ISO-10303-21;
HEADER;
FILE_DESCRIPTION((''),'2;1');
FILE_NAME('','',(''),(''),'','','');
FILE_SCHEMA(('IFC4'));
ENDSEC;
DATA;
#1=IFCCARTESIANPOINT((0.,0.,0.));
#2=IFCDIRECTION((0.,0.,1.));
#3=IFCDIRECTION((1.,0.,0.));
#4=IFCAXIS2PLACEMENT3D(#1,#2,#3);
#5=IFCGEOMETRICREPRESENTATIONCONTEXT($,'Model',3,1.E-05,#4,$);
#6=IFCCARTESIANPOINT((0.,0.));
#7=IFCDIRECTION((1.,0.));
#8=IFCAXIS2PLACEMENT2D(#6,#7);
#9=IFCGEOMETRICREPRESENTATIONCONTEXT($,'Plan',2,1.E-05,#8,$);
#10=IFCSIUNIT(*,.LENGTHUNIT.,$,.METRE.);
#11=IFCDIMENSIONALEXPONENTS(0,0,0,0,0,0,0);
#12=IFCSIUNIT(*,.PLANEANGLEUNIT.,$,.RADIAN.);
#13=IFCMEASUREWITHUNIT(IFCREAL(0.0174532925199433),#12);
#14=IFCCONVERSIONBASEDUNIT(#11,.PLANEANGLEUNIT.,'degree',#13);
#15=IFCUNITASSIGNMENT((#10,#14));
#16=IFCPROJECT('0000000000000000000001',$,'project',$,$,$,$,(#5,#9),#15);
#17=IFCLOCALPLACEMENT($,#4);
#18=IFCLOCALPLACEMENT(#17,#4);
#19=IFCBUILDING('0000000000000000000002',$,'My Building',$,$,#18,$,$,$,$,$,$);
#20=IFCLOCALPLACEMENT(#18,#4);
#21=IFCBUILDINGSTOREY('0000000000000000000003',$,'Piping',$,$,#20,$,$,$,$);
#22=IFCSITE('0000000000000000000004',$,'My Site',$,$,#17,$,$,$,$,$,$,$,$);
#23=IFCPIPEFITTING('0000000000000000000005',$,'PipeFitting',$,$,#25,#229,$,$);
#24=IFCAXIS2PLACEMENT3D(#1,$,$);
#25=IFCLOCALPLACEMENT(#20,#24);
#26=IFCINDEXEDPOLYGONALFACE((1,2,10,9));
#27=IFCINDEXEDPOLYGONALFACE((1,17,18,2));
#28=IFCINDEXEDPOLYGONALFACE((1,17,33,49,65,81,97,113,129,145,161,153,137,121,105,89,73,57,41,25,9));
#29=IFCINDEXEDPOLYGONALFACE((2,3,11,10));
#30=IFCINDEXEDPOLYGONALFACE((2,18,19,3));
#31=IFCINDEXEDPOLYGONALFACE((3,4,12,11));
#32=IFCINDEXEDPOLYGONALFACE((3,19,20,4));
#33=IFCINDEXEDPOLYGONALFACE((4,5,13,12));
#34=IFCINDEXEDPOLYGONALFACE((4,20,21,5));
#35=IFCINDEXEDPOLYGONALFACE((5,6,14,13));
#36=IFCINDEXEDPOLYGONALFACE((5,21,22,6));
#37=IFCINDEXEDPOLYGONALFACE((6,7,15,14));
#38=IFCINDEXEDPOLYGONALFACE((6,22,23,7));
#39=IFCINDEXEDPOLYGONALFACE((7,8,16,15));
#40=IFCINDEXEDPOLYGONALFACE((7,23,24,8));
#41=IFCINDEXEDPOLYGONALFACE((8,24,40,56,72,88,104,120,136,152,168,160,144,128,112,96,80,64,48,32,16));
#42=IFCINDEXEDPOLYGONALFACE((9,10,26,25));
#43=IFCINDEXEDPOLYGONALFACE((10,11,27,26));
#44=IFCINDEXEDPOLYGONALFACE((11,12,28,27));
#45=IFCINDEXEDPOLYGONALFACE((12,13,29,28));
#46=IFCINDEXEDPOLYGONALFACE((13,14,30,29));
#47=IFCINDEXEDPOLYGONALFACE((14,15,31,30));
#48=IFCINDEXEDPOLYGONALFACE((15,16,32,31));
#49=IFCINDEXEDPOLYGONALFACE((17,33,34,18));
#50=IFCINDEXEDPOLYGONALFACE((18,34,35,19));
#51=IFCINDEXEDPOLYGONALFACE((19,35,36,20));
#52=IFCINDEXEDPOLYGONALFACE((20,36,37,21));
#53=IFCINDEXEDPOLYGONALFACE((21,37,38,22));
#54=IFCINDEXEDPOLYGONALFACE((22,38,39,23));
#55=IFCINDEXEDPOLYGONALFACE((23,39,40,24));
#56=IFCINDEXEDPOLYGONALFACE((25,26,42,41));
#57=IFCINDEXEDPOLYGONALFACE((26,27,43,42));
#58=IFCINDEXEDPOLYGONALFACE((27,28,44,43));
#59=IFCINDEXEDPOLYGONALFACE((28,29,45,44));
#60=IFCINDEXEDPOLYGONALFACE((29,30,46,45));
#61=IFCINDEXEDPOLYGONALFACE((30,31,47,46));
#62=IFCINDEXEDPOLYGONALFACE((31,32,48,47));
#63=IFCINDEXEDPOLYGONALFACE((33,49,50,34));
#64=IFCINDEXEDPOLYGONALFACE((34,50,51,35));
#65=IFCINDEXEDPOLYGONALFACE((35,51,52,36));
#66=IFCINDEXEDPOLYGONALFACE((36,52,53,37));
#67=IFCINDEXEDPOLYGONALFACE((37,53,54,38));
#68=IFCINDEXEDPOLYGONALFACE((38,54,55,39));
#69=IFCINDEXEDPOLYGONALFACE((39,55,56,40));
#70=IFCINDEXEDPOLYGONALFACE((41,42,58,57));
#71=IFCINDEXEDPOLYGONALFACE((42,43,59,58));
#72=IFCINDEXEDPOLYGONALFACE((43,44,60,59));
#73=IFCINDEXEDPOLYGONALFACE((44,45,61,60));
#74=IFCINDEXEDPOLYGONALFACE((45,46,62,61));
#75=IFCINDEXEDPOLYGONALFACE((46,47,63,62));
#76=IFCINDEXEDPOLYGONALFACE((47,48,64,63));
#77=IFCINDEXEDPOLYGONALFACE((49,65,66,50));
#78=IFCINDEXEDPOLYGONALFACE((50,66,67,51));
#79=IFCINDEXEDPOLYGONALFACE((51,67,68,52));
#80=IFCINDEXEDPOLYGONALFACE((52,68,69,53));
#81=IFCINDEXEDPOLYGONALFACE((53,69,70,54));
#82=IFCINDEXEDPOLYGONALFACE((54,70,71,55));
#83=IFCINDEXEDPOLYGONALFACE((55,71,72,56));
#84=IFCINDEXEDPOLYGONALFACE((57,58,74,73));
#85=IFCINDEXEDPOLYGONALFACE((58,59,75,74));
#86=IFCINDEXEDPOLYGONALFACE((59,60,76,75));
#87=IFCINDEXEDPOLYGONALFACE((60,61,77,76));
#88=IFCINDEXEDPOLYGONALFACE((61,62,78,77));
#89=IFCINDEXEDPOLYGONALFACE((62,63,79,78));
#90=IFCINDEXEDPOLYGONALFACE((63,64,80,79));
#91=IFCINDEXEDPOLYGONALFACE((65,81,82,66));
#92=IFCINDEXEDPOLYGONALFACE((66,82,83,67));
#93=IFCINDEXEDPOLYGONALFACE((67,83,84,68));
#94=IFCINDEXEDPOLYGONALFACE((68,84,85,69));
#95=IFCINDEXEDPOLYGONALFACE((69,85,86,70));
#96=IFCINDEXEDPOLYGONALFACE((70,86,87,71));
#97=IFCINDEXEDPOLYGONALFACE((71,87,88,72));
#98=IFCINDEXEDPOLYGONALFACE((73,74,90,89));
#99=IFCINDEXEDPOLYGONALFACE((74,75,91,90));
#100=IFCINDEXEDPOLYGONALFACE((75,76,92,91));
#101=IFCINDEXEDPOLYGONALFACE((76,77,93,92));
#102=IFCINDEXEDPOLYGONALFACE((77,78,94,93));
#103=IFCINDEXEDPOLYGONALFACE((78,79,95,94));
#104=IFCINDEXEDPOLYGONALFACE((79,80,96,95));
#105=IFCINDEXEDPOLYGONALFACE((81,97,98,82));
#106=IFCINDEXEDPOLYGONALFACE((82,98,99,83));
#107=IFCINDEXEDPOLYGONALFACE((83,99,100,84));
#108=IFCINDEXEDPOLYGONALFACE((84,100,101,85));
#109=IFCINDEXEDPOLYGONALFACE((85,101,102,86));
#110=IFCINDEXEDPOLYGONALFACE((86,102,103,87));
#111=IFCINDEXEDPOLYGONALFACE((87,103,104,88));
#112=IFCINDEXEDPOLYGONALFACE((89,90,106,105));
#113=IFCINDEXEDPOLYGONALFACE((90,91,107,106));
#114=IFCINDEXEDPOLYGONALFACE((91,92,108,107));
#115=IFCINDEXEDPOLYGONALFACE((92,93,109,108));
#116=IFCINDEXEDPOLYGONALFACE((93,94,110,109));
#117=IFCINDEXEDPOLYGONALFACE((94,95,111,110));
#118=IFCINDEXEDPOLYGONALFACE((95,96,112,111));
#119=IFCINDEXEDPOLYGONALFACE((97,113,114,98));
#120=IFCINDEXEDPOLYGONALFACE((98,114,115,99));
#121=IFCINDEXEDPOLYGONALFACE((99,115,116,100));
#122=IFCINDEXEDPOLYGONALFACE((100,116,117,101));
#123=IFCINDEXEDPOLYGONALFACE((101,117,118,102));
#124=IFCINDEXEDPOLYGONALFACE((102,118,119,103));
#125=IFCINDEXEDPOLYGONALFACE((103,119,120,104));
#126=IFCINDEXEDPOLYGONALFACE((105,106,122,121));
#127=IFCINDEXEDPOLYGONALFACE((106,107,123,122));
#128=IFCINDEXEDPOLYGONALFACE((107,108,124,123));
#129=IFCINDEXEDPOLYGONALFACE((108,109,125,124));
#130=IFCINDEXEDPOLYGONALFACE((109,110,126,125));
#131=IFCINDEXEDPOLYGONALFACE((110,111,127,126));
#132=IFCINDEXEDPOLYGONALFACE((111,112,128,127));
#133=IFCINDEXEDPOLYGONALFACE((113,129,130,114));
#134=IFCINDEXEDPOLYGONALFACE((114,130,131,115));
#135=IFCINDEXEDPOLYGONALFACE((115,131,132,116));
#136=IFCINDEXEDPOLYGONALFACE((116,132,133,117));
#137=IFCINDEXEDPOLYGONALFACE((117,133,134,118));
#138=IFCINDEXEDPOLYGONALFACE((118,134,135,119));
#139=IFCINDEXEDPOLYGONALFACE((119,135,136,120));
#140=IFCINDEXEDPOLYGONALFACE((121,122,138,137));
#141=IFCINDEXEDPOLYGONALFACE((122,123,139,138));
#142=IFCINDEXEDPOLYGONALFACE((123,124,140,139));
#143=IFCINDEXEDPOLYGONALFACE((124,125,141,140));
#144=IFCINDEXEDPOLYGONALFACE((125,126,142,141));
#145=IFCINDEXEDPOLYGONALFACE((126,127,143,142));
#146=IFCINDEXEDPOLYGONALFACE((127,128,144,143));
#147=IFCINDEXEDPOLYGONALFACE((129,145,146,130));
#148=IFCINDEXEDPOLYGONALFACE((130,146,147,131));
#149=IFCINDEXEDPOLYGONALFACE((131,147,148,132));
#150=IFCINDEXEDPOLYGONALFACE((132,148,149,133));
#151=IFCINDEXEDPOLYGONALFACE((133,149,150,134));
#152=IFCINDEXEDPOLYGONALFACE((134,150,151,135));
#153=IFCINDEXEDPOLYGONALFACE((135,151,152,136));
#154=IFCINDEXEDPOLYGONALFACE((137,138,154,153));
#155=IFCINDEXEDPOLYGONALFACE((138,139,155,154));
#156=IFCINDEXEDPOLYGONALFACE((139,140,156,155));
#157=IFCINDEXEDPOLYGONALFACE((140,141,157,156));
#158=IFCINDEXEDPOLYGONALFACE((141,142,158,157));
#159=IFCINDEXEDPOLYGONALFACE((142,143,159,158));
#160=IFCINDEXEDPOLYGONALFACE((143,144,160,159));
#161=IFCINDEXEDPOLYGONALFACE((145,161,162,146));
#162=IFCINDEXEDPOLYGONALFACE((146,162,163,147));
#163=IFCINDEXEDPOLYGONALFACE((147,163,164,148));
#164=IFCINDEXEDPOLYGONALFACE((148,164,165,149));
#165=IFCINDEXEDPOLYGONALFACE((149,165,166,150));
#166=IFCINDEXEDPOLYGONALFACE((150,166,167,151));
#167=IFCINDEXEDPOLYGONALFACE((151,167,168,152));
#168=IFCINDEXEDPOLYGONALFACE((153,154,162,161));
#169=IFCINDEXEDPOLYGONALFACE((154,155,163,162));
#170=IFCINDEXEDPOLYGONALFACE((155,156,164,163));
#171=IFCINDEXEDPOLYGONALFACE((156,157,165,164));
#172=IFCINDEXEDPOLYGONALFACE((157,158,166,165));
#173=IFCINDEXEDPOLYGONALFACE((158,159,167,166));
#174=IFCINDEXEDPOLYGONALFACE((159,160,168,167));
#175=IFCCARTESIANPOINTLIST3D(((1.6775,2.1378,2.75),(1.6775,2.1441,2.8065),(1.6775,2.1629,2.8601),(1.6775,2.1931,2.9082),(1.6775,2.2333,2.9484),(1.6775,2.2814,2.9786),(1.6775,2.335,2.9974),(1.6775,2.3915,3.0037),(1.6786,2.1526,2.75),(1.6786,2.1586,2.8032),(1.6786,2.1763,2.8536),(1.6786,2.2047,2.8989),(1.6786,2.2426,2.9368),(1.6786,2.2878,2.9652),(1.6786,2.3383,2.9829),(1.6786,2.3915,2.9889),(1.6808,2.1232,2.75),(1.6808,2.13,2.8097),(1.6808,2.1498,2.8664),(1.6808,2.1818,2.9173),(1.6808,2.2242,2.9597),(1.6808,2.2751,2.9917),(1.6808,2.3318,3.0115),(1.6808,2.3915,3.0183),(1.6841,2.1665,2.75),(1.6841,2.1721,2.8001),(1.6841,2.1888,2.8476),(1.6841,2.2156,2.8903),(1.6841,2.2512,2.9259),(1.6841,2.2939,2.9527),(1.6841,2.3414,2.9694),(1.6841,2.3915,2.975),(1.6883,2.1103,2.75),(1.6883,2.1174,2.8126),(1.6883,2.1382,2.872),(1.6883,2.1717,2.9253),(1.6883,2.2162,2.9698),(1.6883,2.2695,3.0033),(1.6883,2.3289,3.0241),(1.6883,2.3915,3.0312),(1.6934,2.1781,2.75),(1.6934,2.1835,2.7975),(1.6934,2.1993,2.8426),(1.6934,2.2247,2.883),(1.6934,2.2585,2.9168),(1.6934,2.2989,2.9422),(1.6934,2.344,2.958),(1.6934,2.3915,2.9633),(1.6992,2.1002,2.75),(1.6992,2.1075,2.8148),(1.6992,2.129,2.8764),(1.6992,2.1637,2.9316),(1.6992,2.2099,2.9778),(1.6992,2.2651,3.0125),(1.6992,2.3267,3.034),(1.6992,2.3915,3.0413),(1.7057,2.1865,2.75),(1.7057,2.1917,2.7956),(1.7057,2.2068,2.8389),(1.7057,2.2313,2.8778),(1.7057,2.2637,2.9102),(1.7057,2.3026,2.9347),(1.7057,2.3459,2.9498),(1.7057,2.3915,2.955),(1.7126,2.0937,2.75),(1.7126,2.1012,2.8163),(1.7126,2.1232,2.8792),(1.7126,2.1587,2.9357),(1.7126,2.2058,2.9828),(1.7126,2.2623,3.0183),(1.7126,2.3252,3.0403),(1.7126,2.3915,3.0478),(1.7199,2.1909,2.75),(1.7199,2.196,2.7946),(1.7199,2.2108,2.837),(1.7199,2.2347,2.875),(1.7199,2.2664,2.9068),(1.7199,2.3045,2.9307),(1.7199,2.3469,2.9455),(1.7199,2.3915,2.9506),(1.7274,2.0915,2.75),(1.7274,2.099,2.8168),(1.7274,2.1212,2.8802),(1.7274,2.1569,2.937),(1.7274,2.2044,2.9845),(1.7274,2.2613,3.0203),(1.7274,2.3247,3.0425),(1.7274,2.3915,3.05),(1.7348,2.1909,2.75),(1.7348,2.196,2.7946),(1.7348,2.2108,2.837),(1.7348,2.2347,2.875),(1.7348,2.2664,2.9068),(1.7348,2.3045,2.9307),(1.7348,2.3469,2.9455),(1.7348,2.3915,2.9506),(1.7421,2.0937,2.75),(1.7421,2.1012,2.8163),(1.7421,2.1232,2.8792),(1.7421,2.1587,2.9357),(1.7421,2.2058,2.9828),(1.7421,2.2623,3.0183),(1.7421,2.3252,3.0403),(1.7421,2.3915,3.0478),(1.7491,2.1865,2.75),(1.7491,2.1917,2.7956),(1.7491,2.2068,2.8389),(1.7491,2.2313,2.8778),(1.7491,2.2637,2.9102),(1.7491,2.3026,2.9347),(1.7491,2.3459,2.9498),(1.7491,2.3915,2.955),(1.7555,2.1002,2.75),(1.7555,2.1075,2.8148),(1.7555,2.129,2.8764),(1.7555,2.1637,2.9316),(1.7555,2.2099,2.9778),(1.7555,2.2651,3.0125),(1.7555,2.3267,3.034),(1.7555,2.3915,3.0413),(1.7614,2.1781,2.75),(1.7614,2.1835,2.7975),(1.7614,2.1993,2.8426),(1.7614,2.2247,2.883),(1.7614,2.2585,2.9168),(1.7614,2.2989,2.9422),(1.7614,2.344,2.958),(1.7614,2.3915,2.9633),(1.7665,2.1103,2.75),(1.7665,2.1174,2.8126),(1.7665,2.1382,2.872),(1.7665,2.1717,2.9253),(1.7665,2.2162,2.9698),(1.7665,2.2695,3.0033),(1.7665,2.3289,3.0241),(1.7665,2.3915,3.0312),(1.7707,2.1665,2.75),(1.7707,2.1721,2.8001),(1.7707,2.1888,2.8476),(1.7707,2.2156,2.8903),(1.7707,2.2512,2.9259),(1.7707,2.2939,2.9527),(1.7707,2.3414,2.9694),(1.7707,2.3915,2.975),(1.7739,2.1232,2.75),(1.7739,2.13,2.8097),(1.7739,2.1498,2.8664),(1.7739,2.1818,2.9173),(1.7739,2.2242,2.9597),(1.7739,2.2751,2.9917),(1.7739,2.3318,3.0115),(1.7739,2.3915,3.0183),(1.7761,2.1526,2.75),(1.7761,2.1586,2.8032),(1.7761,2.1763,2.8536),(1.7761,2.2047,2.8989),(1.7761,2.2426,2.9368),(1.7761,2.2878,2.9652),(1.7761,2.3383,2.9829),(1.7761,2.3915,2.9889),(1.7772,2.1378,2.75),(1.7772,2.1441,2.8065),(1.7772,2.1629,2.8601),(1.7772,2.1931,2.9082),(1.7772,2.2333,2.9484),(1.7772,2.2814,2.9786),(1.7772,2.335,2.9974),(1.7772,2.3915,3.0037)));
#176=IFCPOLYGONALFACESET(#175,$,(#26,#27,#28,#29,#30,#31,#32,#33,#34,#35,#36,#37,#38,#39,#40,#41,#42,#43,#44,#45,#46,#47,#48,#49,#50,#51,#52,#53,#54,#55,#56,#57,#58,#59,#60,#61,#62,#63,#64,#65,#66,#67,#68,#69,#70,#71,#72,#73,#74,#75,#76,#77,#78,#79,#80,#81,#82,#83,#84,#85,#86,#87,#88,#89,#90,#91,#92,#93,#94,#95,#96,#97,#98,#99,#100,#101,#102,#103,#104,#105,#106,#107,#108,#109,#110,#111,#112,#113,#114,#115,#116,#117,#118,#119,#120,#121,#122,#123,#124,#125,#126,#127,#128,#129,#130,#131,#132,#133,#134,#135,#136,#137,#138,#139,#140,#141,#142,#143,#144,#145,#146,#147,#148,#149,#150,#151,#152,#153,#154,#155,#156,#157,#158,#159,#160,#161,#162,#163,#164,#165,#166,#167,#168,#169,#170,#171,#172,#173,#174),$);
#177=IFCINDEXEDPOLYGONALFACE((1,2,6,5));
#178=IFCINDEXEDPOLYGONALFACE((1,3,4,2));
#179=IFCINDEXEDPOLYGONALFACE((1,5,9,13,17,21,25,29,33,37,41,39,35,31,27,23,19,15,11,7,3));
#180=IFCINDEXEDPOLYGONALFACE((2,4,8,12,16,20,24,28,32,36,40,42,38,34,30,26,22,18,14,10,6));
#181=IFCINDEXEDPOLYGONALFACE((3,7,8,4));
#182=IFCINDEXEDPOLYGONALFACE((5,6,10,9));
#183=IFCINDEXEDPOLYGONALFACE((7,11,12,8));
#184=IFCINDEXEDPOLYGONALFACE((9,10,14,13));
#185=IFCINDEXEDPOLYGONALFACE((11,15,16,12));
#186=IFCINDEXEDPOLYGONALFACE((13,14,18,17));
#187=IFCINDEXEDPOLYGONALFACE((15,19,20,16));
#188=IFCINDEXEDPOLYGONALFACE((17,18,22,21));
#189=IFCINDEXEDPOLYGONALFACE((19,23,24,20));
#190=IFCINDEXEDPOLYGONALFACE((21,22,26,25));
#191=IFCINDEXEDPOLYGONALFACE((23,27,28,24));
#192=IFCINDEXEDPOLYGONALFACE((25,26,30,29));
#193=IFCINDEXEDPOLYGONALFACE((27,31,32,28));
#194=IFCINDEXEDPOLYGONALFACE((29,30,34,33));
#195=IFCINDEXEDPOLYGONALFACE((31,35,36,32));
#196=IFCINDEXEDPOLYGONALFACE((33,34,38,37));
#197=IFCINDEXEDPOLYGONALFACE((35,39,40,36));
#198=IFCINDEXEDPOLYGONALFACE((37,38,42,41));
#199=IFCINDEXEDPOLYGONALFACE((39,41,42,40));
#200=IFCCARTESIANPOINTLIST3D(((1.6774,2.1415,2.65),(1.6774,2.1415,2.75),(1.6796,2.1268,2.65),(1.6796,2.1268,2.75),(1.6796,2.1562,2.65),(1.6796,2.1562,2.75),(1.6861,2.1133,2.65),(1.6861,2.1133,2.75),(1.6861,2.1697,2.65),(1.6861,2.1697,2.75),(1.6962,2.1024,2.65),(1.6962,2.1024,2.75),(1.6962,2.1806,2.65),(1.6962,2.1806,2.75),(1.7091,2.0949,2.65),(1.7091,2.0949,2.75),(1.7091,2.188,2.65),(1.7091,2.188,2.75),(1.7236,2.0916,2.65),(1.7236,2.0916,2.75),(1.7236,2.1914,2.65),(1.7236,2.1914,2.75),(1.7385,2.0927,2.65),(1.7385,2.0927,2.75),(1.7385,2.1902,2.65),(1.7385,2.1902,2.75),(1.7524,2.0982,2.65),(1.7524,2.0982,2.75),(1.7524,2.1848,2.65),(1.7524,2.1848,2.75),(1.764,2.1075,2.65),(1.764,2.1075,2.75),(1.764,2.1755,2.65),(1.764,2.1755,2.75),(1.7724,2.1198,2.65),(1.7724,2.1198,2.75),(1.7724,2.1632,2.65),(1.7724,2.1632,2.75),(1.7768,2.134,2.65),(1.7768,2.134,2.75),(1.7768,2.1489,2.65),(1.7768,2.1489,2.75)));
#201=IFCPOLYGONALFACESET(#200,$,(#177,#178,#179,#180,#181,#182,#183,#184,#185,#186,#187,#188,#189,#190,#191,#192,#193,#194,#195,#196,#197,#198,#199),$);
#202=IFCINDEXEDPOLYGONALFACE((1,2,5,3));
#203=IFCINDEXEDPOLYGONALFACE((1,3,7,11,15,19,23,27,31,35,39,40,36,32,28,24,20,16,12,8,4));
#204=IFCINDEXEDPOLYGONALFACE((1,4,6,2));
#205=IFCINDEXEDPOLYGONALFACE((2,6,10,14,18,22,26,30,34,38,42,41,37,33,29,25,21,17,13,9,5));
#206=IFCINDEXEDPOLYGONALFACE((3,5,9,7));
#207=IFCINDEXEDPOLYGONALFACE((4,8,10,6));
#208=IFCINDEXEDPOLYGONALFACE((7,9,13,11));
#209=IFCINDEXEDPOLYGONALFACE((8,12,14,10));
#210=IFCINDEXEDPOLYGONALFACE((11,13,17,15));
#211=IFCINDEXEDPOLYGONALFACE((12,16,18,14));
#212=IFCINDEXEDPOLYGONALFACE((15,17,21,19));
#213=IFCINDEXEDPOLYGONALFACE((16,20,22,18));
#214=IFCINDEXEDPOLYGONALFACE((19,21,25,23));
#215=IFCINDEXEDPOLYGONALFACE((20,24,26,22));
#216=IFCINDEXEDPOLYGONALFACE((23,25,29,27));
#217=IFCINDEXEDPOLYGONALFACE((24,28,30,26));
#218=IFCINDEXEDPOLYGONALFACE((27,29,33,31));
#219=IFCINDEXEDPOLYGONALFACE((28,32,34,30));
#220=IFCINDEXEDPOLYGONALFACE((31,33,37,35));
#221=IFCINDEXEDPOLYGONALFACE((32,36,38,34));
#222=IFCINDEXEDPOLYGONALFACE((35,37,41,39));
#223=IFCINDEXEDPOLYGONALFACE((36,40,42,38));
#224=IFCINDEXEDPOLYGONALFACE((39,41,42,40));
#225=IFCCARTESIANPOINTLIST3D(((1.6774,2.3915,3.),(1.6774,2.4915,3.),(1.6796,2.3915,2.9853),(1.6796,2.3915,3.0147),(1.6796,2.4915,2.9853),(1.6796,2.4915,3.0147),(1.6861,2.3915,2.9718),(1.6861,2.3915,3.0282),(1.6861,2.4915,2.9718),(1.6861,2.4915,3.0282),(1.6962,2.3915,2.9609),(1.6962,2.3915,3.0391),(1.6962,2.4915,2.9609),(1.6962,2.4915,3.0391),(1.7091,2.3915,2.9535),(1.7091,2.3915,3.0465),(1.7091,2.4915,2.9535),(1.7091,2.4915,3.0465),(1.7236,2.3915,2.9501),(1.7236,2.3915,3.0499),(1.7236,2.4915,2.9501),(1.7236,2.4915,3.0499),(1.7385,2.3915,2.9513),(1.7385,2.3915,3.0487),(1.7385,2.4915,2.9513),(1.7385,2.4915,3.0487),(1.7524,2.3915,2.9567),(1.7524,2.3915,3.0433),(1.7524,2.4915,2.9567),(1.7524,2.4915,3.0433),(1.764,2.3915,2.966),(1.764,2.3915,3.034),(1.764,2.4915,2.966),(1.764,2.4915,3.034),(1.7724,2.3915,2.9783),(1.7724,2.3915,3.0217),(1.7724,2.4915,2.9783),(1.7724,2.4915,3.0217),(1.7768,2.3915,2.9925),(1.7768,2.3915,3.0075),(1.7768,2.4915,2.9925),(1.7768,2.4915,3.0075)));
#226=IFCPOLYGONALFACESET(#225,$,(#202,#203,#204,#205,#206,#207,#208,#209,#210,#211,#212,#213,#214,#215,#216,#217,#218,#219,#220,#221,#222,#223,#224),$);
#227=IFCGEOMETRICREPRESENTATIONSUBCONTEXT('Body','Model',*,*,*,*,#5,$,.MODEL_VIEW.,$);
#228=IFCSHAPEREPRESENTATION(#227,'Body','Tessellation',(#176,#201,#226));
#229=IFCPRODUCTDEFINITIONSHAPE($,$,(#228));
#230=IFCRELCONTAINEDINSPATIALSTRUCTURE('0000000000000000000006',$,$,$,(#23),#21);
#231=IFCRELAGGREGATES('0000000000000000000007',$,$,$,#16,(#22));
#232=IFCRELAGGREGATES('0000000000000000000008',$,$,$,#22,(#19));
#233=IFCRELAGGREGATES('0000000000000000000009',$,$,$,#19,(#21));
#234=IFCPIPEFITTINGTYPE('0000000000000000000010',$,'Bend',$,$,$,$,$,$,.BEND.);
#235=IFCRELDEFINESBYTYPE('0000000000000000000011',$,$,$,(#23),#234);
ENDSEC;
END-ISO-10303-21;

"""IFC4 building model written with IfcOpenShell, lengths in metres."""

from ifc_helpers import new_model, entity, si_unit, converted_unit, frame, origin_with_axes, origin_2d_with_axis, place, context, subcontext, project, spatial, circle, extrude, source, transform, mapped, type_object, type_shapes, element, save


model = new_model("IFC4")

# Units and contexts
model_context = context("Model", 3, precision=1e-05, world=origin_with_axes())
plan_context = context("Plan", 2, precision=1e-05, world=origin_2d_with_axis())
body_context = subcontext(model_context, "Body", "Model", "MODEL_VIEW")
ifc_project = project(units=[si_unit("LENGTHUNIT", "METRE"), converted_unit("PLANEANGLEUNIT", "degree", entity("IfcReal", 0.0174532925199433), si_unit("PLANEANGLEUNIT", "RADIAN"), dimensions=[0, 0, 0, 0, 0, 0, 0])], contexts=[model_context, plan_context])

# Site, building, storey
site_placement = place(None, origin_with_axes())
site = spatial("IfcSite", under=ifc_project, at=site_placement, Name="My Site")
building_placement = place(site_placement, origin_with_axes())
building = spatial("IfcBuilding", under=site, at=building_placement, Name="My Building")
storey_placement = place(building_placement, origin_with_axes())
storey = spatial("IfcBuildingStorey", under=building, at=storey_placement, Name="Piping")

# Pipe fitting
pipe_fitting_type_1 = type_object("IfcPipeFittingType", Name="Bend", PredefinedType="BEND")
shared_shape = source(origin_with_axes(), body_context, "Body", "SolidModel", [
    entity("IfcSweptDiskSolid", entity("IfcIndexedPolyCurve", entity("IfcCartesianPointList3D", [[0.0, 0.0, -0.1], [0.0, 0.0732, -0.2768], [0.0, 0.25, -0.35]]), [entity("IfcArcIndex", [1, 2, 3])]), 0.05),
    extrude(circle(Radius=0.05), origin_with_axes(), (0.0, 0.0, -1.0), 0.1),
    extrude(circle(Radius=0.05), frame((0.0, 0.25, -0.35), z_axis=(0.0, 1.0, 0.0), x_axis=(1.0, 0.0, 0.0)), (0.0, 0.0, 1.0), 0.1),
])
type_shapes(pipe_fitting_type_1, [shared_shape])
for number, where, z_axis, x_axis, name in (
    (1, (1.7274, 2.1415, 2.65), (0.0, 0.0, -1.0), (-1.0, 0.0, 0.0), "PipeFitting"),
):
    element("IfcPipeFitting", number, at=place(storey_placement, frame(where, z_axis=z_axis, x_axis=x_axis)), inside=storey, type_object=pipe_fitting_type_1, Name=name, context=body_context, shape_type="MappedRepresentation", body=[
        mapped(shared_shape, transform((0.0, 0.0, 0.0), x_axis=(1.0, 0.0, 0.0), y_axis=(0.0, 1.0, 0.0), z_axis=(0.0, 0.0, 1.0), scale=1.0)),
    ])

save(model, "model.ifc")
